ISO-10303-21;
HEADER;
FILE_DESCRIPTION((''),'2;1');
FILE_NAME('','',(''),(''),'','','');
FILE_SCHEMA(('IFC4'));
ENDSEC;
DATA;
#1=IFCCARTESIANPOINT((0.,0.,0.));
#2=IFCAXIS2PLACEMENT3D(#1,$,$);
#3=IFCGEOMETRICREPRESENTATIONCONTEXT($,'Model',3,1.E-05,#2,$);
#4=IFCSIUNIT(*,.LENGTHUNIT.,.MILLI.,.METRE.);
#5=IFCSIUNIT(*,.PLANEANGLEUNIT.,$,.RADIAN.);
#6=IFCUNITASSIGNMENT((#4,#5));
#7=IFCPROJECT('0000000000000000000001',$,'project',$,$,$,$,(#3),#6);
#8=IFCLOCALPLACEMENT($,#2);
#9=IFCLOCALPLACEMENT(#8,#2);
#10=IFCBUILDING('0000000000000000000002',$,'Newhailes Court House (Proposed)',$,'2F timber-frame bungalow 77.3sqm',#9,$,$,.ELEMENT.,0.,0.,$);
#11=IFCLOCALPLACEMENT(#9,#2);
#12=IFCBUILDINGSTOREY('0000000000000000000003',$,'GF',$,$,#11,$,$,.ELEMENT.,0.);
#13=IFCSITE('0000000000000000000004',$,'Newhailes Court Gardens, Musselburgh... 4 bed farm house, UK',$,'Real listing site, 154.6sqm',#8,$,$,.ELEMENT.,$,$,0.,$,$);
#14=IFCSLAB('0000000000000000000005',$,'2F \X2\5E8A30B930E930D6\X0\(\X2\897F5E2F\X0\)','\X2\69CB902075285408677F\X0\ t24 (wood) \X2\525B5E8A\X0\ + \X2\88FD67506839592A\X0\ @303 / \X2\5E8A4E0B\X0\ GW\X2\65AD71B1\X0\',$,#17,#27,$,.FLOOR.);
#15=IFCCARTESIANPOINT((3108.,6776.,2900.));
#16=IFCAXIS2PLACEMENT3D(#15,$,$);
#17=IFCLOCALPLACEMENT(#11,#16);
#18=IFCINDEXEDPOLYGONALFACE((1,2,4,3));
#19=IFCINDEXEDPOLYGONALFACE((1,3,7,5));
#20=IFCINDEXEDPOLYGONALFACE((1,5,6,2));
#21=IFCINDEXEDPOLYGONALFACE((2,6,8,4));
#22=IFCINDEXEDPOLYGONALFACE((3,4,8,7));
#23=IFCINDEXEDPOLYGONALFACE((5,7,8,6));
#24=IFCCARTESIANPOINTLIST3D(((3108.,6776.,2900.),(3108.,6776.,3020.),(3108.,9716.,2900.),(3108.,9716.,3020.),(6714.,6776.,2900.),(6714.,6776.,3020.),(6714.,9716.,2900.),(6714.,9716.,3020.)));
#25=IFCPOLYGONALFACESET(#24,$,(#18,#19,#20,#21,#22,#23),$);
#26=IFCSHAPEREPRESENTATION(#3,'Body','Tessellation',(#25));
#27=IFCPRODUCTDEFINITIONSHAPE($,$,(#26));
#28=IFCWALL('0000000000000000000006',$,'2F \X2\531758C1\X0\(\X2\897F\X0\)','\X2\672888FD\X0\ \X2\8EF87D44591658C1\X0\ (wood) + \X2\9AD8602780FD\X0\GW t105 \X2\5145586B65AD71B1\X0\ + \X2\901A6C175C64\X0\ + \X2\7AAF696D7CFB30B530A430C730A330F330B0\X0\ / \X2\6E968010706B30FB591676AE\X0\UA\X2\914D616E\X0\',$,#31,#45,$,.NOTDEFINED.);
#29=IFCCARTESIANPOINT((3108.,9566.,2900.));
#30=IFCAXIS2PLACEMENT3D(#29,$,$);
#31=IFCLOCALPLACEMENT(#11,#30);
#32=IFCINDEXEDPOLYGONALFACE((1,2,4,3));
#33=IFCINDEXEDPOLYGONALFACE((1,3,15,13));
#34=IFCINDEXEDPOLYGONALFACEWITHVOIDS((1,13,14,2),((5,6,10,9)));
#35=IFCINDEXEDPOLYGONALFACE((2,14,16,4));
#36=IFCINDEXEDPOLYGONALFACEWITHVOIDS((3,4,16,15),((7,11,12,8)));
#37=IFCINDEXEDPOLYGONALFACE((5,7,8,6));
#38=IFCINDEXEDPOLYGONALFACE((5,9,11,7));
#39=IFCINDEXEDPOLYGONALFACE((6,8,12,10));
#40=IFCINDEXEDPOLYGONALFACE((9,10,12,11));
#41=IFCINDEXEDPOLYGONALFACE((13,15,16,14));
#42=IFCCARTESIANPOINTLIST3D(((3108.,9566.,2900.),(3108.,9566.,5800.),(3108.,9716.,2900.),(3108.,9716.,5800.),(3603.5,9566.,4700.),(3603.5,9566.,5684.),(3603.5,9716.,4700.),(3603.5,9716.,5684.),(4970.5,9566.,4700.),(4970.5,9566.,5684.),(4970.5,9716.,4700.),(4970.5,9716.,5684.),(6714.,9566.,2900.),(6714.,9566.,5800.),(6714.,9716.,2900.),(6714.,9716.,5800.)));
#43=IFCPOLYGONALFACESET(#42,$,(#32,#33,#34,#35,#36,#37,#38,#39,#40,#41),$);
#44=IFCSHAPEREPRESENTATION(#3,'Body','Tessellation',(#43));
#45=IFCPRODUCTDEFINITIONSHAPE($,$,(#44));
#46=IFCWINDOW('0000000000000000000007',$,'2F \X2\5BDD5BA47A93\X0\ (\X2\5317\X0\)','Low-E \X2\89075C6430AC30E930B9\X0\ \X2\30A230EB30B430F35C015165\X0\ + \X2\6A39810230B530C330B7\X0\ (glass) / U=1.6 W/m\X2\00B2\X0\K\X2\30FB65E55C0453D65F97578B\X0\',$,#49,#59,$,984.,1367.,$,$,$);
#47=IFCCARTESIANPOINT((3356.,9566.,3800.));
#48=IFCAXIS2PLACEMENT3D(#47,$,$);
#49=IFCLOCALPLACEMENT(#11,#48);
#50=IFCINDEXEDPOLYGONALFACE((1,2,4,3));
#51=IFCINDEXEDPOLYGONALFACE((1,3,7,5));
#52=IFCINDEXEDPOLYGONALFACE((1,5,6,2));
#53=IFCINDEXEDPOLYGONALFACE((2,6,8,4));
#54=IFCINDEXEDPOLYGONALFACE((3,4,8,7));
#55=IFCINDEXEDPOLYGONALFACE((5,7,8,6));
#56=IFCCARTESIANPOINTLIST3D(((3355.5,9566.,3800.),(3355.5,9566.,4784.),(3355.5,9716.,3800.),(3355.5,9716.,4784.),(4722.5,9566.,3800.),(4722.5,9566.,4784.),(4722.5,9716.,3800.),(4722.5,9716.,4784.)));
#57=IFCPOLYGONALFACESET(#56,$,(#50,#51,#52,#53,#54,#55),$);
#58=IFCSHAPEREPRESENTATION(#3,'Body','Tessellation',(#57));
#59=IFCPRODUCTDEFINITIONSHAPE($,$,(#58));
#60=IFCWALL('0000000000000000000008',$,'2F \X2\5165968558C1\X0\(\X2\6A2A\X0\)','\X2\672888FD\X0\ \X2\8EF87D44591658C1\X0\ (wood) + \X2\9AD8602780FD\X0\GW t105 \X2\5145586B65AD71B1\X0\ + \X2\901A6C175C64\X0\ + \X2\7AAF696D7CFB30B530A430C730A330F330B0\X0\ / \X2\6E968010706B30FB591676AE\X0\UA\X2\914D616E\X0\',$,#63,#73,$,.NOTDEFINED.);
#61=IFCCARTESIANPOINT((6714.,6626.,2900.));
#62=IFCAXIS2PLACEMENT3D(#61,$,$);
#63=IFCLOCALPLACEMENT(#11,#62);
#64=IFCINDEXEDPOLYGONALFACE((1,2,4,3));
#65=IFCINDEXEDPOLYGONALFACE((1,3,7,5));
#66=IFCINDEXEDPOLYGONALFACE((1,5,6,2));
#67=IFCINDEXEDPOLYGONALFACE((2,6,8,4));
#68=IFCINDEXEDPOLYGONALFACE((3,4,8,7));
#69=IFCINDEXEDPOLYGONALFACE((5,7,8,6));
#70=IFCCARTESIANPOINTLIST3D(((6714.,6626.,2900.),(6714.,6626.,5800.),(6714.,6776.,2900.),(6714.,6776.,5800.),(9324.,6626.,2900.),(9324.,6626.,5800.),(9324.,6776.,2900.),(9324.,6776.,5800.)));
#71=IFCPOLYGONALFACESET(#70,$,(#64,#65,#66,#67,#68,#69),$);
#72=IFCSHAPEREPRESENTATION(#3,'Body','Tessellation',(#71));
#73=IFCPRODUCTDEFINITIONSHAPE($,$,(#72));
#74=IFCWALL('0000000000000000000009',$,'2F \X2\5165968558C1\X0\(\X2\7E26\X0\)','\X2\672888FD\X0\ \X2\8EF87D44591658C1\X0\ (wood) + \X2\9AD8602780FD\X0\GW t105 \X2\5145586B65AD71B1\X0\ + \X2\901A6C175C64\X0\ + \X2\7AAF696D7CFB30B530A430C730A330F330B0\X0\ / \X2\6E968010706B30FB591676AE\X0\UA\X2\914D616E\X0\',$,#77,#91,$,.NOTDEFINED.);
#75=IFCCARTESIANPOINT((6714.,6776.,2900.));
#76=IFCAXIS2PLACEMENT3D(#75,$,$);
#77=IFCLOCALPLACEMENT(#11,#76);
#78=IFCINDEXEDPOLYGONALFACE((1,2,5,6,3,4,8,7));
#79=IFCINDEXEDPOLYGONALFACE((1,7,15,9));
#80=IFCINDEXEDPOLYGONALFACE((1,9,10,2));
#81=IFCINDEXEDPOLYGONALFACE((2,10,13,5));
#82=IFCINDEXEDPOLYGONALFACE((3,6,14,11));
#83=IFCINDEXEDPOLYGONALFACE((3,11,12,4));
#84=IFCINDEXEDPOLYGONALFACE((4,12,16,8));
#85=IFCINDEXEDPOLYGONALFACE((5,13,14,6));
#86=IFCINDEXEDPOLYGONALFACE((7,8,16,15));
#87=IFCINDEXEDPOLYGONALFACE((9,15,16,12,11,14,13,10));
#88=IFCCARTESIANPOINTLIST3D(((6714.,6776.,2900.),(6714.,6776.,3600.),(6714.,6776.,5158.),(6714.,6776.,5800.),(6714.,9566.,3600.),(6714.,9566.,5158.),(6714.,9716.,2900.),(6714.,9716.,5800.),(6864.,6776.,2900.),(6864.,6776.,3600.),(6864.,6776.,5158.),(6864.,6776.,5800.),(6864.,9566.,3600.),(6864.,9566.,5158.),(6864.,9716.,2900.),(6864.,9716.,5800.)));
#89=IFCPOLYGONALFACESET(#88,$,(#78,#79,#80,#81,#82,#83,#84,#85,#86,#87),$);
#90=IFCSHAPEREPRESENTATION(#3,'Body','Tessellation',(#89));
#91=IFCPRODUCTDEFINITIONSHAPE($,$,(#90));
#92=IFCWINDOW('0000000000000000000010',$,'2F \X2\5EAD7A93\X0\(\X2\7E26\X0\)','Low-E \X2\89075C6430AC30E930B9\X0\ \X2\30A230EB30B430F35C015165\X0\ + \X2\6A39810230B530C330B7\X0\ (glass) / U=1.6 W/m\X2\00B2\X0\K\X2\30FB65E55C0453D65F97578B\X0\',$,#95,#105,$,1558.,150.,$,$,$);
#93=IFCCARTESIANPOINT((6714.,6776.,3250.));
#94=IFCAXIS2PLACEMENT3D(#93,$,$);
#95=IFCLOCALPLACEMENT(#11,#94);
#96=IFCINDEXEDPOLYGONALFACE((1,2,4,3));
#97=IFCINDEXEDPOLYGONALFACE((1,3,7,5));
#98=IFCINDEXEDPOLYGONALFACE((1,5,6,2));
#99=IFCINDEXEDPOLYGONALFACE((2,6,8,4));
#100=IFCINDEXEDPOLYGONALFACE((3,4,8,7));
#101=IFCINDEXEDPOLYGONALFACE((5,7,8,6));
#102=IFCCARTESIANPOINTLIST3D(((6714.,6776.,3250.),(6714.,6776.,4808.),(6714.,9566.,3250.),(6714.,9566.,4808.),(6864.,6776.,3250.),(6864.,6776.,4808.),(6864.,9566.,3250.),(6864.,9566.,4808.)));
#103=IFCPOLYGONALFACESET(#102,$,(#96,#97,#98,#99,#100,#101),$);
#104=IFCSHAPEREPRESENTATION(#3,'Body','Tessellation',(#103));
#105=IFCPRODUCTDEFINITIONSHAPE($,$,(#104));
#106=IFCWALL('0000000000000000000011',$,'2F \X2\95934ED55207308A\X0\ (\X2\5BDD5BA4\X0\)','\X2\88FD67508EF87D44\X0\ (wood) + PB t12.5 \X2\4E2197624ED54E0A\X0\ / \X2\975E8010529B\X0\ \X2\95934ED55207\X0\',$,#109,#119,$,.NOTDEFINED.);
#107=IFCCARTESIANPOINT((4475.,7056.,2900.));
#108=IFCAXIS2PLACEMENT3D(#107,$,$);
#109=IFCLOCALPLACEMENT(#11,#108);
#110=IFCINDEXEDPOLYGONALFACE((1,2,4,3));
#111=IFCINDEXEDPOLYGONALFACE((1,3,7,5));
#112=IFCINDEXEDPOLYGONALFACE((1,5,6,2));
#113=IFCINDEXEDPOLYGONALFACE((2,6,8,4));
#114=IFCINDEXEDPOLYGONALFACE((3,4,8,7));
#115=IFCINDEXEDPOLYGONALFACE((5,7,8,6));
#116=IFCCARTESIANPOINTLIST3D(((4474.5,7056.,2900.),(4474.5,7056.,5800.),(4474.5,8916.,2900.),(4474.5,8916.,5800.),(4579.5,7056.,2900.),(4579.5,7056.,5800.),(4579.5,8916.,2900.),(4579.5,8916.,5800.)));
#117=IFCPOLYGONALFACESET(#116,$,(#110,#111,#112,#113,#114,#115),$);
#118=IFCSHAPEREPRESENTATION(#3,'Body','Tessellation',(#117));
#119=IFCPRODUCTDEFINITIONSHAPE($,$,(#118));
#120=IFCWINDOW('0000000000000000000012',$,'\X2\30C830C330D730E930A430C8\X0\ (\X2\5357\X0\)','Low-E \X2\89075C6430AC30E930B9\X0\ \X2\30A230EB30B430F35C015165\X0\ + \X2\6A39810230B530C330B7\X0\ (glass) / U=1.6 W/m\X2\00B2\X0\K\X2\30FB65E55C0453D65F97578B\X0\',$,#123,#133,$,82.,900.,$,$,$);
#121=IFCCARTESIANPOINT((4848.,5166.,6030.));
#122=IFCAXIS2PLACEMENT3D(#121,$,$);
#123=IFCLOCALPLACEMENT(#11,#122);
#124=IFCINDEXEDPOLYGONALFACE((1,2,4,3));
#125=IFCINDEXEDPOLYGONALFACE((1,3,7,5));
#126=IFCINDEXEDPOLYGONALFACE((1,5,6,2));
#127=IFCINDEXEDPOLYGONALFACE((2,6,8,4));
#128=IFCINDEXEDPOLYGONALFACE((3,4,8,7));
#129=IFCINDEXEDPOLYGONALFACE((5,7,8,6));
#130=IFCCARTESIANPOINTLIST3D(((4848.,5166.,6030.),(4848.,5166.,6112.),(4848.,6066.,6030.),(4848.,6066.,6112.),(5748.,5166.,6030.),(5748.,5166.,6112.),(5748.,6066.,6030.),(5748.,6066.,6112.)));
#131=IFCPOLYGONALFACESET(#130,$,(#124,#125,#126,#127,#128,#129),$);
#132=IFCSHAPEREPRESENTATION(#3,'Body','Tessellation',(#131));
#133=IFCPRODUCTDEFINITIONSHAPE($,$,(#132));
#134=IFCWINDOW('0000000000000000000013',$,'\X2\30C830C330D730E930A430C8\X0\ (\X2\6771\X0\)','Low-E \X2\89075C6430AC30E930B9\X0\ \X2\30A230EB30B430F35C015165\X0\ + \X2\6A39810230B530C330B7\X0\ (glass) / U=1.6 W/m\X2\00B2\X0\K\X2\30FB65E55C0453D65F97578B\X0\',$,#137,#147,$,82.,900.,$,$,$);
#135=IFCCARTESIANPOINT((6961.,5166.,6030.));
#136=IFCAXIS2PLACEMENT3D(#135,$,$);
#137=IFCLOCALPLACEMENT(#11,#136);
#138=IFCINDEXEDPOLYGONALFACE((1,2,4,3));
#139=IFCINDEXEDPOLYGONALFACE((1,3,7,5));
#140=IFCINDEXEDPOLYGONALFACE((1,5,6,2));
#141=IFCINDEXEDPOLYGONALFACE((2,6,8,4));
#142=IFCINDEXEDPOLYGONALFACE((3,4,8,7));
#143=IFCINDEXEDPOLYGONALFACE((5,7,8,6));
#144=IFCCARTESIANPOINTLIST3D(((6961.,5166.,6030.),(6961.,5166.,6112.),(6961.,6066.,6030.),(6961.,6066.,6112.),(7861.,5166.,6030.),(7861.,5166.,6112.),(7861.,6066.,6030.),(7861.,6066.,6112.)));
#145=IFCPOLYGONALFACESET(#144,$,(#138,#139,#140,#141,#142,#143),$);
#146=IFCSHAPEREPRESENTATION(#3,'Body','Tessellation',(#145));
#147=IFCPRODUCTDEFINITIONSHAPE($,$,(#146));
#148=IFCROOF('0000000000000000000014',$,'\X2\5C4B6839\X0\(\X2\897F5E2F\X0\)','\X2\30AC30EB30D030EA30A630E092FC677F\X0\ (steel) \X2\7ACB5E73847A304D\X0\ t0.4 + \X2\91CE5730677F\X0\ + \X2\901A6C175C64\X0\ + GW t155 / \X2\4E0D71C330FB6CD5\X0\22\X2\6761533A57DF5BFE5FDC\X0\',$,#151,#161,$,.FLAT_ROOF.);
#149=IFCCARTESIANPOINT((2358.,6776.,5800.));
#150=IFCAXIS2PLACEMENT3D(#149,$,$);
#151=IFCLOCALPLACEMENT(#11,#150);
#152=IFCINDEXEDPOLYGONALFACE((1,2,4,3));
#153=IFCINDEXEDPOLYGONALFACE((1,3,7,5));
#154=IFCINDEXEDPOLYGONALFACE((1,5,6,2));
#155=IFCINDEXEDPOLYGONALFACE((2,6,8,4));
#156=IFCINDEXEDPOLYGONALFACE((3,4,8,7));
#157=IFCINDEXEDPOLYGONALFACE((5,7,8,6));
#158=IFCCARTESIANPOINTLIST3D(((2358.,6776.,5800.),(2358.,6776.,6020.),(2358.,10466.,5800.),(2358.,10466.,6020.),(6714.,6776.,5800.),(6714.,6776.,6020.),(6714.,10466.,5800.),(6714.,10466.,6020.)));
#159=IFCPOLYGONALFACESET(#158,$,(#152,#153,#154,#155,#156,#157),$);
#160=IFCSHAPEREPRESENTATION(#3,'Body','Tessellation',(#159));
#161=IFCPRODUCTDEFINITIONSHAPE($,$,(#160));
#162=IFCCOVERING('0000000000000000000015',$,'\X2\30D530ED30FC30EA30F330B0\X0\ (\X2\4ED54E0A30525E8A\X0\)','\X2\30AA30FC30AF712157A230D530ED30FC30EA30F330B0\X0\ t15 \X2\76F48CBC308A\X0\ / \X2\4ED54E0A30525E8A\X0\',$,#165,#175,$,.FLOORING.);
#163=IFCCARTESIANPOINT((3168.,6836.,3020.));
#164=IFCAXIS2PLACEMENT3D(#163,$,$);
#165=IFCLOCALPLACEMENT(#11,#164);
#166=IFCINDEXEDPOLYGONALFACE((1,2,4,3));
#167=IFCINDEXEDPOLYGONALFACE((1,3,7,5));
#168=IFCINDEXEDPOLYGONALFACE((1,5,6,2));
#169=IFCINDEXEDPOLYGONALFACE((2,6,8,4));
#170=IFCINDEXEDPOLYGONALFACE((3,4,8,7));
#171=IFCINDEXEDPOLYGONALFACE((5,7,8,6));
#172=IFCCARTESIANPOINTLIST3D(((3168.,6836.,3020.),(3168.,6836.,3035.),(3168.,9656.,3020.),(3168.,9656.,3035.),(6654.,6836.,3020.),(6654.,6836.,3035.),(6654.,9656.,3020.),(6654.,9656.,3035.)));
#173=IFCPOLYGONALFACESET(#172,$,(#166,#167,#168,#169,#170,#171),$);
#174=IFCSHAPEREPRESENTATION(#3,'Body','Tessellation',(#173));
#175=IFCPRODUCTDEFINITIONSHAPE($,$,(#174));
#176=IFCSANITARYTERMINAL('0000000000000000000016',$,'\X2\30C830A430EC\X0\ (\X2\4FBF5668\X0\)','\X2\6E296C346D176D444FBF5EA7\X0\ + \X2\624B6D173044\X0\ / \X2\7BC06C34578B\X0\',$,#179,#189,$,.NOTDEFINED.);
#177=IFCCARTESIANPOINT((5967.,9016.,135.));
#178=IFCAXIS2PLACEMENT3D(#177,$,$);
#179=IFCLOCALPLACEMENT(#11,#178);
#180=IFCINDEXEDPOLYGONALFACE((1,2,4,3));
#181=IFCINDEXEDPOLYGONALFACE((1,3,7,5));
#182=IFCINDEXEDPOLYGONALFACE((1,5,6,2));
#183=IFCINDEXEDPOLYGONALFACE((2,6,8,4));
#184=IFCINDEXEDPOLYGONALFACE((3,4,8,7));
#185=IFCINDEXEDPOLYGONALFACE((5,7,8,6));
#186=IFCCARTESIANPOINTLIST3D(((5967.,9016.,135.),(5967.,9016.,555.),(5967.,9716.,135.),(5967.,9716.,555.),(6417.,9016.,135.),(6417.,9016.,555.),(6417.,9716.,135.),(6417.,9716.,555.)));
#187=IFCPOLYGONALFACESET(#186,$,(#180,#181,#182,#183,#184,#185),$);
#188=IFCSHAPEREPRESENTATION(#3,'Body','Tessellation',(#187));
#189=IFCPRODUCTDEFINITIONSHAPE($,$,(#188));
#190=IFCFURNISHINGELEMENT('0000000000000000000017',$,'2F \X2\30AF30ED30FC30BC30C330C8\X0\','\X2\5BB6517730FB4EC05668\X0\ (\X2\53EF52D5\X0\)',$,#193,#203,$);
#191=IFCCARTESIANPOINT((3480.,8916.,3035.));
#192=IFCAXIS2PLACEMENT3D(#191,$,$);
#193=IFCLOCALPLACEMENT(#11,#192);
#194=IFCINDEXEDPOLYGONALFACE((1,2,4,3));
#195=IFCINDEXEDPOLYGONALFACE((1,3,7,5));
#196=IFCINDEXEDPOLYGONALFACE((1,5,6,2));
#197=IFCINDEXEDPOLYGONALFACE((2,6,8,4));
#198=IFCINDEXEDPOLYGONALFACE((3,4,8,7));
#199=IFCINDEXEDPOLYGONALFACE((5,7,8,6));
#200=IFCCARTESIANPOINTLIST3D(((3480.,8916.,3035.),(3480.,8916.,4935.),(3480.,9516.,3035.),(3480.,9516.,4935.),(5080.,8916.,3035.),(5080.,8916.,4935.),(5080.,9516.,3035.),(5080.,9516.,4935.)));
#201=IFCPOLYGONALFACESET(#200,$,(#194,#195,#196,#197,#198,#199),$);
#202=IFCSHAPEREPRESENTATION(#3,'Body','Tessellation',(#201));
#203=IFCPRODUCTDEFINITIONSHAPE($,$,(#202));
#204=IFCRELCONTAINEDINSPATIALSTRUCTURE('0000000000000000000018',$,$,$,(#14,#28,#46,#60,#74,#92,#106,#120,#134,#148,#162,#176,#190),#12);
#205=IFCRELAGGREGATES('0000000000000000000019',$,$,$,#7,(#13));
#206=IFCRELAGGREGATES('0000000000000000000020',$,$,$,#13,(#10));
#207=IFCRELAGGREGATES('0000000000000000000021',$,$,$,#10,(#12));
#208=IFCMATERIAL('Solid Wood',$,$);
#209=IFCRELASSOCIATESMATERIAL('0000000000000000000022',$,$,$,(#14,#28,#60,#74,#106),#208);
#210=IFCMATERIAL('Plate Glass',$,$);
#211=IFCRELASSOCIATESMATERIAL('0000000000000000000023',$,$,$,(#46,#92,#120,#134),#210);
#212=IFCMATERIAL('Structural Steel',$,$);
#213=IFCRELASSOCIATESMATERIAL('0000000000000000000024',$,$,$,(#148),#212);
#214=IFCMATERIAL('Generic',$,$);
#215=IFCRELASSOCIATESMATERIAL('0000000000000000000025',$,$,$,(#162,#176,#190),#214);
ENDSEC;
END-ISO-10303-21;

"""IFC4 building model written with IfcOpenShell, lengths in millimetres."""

from ifc_helpers import new_model, si_unit, frame, frame_2d, origin, place, context, project, spatial, rectangle, extrude, material, element, fill, save


model = new_model("IFC4")

# Units and contexts
model_context = context("Model", 3, precision=1e-05, world=origin())
ifc_project = project(units=[si_unit("LENGTHUNIT", "METRE", prefix="MILLI"), si_unit("PLANEANGLEUNIT", "RADIAN")], contexts=[model_context])

# Site, building, storey
site_placement = place(None, origin())
site = spatial("IfcSite", under=ifc_project, at=site_placement, Name="Newhailes Court Gardens, Musselburgh... 4 bed farm house, UK", ObjectType="Real listing site, 154.6sqm", CompositionType="ELEMENT", RefElevation=0.0)
building_placement = place(site_placement, origin())
building = spatial("IfcBuilding", under=site, at=building_placement, Name="Newhailes Court House (Proposed)", ObjectType="2F timber-frame bungalow 77.3sqm", CompositionType="ELEMENT", ElevationOfRefHeight=0.0, ElevationOfTerrain=0.0)
storey_placement = place(building_placement, origin())
storey = spatial("IfcBuildingStorey", under=building, at=storey_placement, Name="GF", CompositionType="ELEMENT", Elevation=0.0)

# Slab
ifc_material_1 = material(Name="Solid Wood")
slab_placement = place(storey_placement, frame((3108.0, 6776.0, 2900.0)))
element("IfcSlab", 1, at=slab_placement, inside=storey, material=ifc_material_1, Name="2F 床スラブ(西帯)", Description="構造用合板 t24 (wood) 剛床 + 製材根太 @303 / 床下 GW断熱", PredefinedType="FLOOR", context=model_context, shape_type="SweptSolid", body=[
    extrude(rectangle(XDim=3606.0, YDim=2940.0, at=frame_2d((1803.0, 1470.0))), frame((3108.0, 6776.0, 2900.0)), (0.0, 0.0, 1.0), 120.0),
])

# Wall, opening, window
wall_1_placement = place(storey_placement, frame((3108.0, 9566.0, 2900.0)))
wall_1 = element("IfcWall", 2, at=wall_1_placement, inside=storey, material=ifc_material_1, Name="2F 北壁(西)", Description="木製 軸組外壁 (wood) + 高性能GW t105 充填断熱 + 通気層 + 窯業系サイディング / 準耐火・外皮UA配慮", PredefinedType="NOTDEFINED", context=model_context, shape_type="SweptSolid", body=[
    extrude(rectangle(XDim=3606.0, YDim=150.0, at=frame_2d((1803.0, 75.0))), frame((3108.0, 9566.0, 2900.0)), (0.0, 0.0, 1.0), 2900.0),
])
opening_1_placement = place(storey_placement, frame((3356.0, 9566.0, 3800.0)))
opening_1 = element("IfcOpeningElement", 3, at=opening_1_placement, cuts=wall_1, PredefinedType="NOTDEFINED", context=model_context, shape_type="SweptSolid", body=[
    extrude(rectangle(XDim=1367.0, YDim=150.0, at=frame_2d((683.0, 75.0))), frame((3356.0, 9566.0, 3800.0)), (0.0, 0.0, 1.0), 984.0),
])
ifc_material_2 = material(Name="Plate Glass")
window_1_placement = place(storey_placement, frame((3356.0, 9566.0, 3800.0)))
window_1 = element("IfcWindow", 4, at=window_1_placement, inside=storey, material=ifc_material_2, Name="2F 寝室窓 (北)", Description="Low-E 複層ガラス アルゴン封入 + 樹脂サッシ (glass) / U=1.6 W/m²K・日射取得型", OverallHeight=984.0, OverallWidth=1367.0, context=model_context, shape_type="SweptSolid", body=[
    extrude(rectangle(XDim=1367.0, YDim=150.0, at=frame_2d((683.0, 75.0))), frame((3356.0, 9566.0, 3800.0)), (0.0, 0.0, 1.0), 984.0),
])
fill(opening_1, window_1)

# Wall
wall_2_placement = place(storey_placement, frame((6714.0, 6626.0, 2900.0)))
element("IfcWall", 5, at=wall_2_placement, inside=storey, material=ifc_material_1, Name="2F 入隅壁(横)", Description="木製 軸組外壁 (wood) + 高性能GW t105 充填断熱 + 通気層 + 窯業系サイディング / 準耐火・外皮UA配慮", PredefinedType="NOTDEFINED", context=model_context, shape_type="SweptSolid", body=[
    extrude(rectangle(XDim=2610.0, YDim=150.0, at=frame_2d((1305.0, 75.0))), frame((6714.0, 6626.0, 2900.0)), (0.0, 0.0, 1.0), 2900.0),
])

# Wall, opening, window
wall_3_placement = place(storey_placement, frame((6714.0, 6776.0, 2900.0)))
wall_3 = element("IfcWall", 6, at=wall_3_placement, inside=storey, material=ifc_material_1, Name="2F 入隅壁(縦)", Description="木製 軸組外壁 (wood) + 高性能GW t105 充填断熱 + 通気層 + 窯業系サイディング / 準耐火・外皮UA配慮", PredefinedType="NOTDEFINED", context=model_context, shape_type="SweptSolid", body=[
    extrude(rectangle(XDim=150.0, YDim=2940.0, at=frame_2d((75.0, 1470.0))), frame((6714.0, 6776.0, 2900.0)), (0.0, 0.0, 1.0), 2900.0),
])
opening_2_placement = place(storey_placement, frame((6714.0, 6776.0, 3250.0)))
opening_2 = element("IfcOpeningElement", 7, at=opening_2_placement, cuts=wall_3, PredefinedType="NOTDEFINED", context=model_context, shape_type="SweptSolid", body=[
    extrude(rectangle(XDim=150.0, YDim=2790.0, at=frame_2d((75.0, 1395.0))), frame((6714.0, 6776.0, 3250.0)), (0.0, 0.0, 1.0), 1558.0),
])
window_2_placement = place(storey_placement, frame((6714.0, 6776.0, 3250.0)))
window_2 = element("IfcWindow", 8, at=window_2_placement, inside=storey, material=ifc_material_2, Name="2F 庭窓(縦)", Description="Low-E 複層ガラス アルゴン封入 + 樹脂サッシ (glass) / U=1.6 W/m²K・日射取得型", OverallHeight=1558.0, OverallWidth=150.0, context=model_context, shape_type="SweptSolid", body=[
    extrude(rectangle(XDim=150.0, YDim=2790.0, at=frame_2d((75.0, 1395.0))), frame((6714.0, 6776.0, 3250.0)), (0.0, 0.0, 1.0), 1558.0),
])
fill(opening_2, window_2)

# Wall
wall_4_placement = place(storey_placement, frame((4475.0, 7056.0, 2900.0)))
element("IfcWall", 9, at=wall_4_placement, inside=storey, material=ifc_material_1, Name="2F 間仕切り (寝室)", Description="製材軸組 (wood) + PB t12.5 両面仕上 / 非耐力 間仕切", PredefinedType="NOTDEFINED", context=model_context, shape_type="SweptSolid", body=[
    extrude(rectangle(XDim=105.0, YDim=1860.0, at=frame_2d((52.0, 930.0))), frame((4475.0, 7056.0, 2900.0)), (0.0, 0.0, 1.0), 2900.0),
])

# Windows
window_3_placement = place(storey_placement, frame((4848.0, 5166.0, 6030.0)))
element("IfcWindow", 10, at=window_3_placement, inside=storey, material=ifc_material_2, Name="トップライト (南)", Description="Low-E 複層ガラス アルゴン封入 + 樹脂サッシ (glass) / U=1.6 W/m²K・日射取得型", OverallHeight=82.0, OverallWidth=900.0, context=model_context, shape_type="SweptSolid", body=[
    extrude(rectangle(XDim=900.0, YDim=900.0, at=frame_2d((450.0, 450.0))), frame((4848.0, 5166.0, 6030.0)), (0.0, 0.0, 1.0), 82.0),
])
window_4_placement = place(storey_placement, frame((6961.0, 5166.0, 6030.0)))
element("IfcWindow", 11, at=window_4_placement, inside=storey, material=ifc_material_2, Name="トップライト (東)", Description="Low-E 複層ガラス アルゴン封入 + 樹脂サッシ (glass) / U=1.6 W/m²K・日射取得型", OverallHeight=82.0, OverallWidth=900.0, context=model_context, shape_type="SweptSolid", body=[
    extrude(rectangle(XDim=900.0, YDim=900.0, at=frame_2d((450.0, 450.0))), frame((6961.0, 5166.0, 6030.0)), (0.0, 0.0, 1.0), 82.0),
])

# Roof
ifc_material_3 = material(Name="Structural Steel")
for number, where, name in (
    (12, (2358.0, 6776.0, 5800.0), "屋根(西帯)"),
):
    element("IfcRoof", number, at=place(storey_placement, frame(where)), inside=storey, material=ifc_material_3, Name=name, Description="ガルバリウム鋼板 (steel) 立平葺き t0.4 + 野地板 + 通気層 + GW t155 / 不燃・法22条区域対応", PredefinedType="FLAT_ROOF", context=model_context, shape_type="SweptSolid", body=[
        extrude(rectangle(XDim=4356.0, YDim=3690.0, at=frame_2d((2178.0, 1845.0))), frame((2358.0, 6776.0, 5800.0)), (0.0, 0.0, 1.0), 220.0),
    ])

# Covering
ifc_material_4 = material(Name="Generic")
covering_placement = place(storey_placement, frame((3168.0, 6836.0, 3020.0)))
element("IfcCovering", 13, at=covering_placement, inside=storey, material=ifc_material_4, Name="フローリング (仕上げ床)", Description="オーク無垢フローリング t15 直貼り / 仕上げ床", PredefinedType="FLOORING", context=model_context, shape_type="SweptSolid", body=[
    extrude(rectangle(XDim=3486.0, YDim=2820.0, at=frame_2d((1743.0, 1410.0))), frame((3168.0, 6836.0, 3020.0)), (0.0, 0.0, 1.0), 15.0),
])

# Sanitary terminal
sanitary_terminal_placement = place(storey_placement, frame((5967.0, 9016.0, 135.0)))
element("IfcSanitaryTerminal", 14, at=sanitary_terminal_placement, inside=storey, material=ifc_material_4, Name="トイレ (便器)", Description="温水洗浄便座 + 手洗い / 節水型", PredefinedType="NOTDEFINED", context=model_context, shape_type="SweptSolid", body=[
    extrude(rectangle(XDim=450.0, YDim=700.0, at=frame_2d((225.0, 350.0))), frame((5967.0, 9016.0, 135.0)), (0.0, 0.0, 1.0), 420.0),
])

# Furnishing element
furnishing_1_placement = place(storey_placement, frame((3480.0, 8916.0, 3035.0)))
element("IfcFurnishingElement", 15, at=furnishing_1_placement, inside=storey, material=ifc_material_4, Name="2F クローゼット", Description="家具・什器 (可動)", context=model_context, shape_type="SweptSolid", body=[
    extrude(rectangle(XDim=1600.0, YDim=600.0, at=frame_2d((800.0, 300.0))), frame((3480.0, 8916.0, 3035.0)), (0.0, 0.0, 1.0), 1900.0),
])

save(model, "model.ifc")
